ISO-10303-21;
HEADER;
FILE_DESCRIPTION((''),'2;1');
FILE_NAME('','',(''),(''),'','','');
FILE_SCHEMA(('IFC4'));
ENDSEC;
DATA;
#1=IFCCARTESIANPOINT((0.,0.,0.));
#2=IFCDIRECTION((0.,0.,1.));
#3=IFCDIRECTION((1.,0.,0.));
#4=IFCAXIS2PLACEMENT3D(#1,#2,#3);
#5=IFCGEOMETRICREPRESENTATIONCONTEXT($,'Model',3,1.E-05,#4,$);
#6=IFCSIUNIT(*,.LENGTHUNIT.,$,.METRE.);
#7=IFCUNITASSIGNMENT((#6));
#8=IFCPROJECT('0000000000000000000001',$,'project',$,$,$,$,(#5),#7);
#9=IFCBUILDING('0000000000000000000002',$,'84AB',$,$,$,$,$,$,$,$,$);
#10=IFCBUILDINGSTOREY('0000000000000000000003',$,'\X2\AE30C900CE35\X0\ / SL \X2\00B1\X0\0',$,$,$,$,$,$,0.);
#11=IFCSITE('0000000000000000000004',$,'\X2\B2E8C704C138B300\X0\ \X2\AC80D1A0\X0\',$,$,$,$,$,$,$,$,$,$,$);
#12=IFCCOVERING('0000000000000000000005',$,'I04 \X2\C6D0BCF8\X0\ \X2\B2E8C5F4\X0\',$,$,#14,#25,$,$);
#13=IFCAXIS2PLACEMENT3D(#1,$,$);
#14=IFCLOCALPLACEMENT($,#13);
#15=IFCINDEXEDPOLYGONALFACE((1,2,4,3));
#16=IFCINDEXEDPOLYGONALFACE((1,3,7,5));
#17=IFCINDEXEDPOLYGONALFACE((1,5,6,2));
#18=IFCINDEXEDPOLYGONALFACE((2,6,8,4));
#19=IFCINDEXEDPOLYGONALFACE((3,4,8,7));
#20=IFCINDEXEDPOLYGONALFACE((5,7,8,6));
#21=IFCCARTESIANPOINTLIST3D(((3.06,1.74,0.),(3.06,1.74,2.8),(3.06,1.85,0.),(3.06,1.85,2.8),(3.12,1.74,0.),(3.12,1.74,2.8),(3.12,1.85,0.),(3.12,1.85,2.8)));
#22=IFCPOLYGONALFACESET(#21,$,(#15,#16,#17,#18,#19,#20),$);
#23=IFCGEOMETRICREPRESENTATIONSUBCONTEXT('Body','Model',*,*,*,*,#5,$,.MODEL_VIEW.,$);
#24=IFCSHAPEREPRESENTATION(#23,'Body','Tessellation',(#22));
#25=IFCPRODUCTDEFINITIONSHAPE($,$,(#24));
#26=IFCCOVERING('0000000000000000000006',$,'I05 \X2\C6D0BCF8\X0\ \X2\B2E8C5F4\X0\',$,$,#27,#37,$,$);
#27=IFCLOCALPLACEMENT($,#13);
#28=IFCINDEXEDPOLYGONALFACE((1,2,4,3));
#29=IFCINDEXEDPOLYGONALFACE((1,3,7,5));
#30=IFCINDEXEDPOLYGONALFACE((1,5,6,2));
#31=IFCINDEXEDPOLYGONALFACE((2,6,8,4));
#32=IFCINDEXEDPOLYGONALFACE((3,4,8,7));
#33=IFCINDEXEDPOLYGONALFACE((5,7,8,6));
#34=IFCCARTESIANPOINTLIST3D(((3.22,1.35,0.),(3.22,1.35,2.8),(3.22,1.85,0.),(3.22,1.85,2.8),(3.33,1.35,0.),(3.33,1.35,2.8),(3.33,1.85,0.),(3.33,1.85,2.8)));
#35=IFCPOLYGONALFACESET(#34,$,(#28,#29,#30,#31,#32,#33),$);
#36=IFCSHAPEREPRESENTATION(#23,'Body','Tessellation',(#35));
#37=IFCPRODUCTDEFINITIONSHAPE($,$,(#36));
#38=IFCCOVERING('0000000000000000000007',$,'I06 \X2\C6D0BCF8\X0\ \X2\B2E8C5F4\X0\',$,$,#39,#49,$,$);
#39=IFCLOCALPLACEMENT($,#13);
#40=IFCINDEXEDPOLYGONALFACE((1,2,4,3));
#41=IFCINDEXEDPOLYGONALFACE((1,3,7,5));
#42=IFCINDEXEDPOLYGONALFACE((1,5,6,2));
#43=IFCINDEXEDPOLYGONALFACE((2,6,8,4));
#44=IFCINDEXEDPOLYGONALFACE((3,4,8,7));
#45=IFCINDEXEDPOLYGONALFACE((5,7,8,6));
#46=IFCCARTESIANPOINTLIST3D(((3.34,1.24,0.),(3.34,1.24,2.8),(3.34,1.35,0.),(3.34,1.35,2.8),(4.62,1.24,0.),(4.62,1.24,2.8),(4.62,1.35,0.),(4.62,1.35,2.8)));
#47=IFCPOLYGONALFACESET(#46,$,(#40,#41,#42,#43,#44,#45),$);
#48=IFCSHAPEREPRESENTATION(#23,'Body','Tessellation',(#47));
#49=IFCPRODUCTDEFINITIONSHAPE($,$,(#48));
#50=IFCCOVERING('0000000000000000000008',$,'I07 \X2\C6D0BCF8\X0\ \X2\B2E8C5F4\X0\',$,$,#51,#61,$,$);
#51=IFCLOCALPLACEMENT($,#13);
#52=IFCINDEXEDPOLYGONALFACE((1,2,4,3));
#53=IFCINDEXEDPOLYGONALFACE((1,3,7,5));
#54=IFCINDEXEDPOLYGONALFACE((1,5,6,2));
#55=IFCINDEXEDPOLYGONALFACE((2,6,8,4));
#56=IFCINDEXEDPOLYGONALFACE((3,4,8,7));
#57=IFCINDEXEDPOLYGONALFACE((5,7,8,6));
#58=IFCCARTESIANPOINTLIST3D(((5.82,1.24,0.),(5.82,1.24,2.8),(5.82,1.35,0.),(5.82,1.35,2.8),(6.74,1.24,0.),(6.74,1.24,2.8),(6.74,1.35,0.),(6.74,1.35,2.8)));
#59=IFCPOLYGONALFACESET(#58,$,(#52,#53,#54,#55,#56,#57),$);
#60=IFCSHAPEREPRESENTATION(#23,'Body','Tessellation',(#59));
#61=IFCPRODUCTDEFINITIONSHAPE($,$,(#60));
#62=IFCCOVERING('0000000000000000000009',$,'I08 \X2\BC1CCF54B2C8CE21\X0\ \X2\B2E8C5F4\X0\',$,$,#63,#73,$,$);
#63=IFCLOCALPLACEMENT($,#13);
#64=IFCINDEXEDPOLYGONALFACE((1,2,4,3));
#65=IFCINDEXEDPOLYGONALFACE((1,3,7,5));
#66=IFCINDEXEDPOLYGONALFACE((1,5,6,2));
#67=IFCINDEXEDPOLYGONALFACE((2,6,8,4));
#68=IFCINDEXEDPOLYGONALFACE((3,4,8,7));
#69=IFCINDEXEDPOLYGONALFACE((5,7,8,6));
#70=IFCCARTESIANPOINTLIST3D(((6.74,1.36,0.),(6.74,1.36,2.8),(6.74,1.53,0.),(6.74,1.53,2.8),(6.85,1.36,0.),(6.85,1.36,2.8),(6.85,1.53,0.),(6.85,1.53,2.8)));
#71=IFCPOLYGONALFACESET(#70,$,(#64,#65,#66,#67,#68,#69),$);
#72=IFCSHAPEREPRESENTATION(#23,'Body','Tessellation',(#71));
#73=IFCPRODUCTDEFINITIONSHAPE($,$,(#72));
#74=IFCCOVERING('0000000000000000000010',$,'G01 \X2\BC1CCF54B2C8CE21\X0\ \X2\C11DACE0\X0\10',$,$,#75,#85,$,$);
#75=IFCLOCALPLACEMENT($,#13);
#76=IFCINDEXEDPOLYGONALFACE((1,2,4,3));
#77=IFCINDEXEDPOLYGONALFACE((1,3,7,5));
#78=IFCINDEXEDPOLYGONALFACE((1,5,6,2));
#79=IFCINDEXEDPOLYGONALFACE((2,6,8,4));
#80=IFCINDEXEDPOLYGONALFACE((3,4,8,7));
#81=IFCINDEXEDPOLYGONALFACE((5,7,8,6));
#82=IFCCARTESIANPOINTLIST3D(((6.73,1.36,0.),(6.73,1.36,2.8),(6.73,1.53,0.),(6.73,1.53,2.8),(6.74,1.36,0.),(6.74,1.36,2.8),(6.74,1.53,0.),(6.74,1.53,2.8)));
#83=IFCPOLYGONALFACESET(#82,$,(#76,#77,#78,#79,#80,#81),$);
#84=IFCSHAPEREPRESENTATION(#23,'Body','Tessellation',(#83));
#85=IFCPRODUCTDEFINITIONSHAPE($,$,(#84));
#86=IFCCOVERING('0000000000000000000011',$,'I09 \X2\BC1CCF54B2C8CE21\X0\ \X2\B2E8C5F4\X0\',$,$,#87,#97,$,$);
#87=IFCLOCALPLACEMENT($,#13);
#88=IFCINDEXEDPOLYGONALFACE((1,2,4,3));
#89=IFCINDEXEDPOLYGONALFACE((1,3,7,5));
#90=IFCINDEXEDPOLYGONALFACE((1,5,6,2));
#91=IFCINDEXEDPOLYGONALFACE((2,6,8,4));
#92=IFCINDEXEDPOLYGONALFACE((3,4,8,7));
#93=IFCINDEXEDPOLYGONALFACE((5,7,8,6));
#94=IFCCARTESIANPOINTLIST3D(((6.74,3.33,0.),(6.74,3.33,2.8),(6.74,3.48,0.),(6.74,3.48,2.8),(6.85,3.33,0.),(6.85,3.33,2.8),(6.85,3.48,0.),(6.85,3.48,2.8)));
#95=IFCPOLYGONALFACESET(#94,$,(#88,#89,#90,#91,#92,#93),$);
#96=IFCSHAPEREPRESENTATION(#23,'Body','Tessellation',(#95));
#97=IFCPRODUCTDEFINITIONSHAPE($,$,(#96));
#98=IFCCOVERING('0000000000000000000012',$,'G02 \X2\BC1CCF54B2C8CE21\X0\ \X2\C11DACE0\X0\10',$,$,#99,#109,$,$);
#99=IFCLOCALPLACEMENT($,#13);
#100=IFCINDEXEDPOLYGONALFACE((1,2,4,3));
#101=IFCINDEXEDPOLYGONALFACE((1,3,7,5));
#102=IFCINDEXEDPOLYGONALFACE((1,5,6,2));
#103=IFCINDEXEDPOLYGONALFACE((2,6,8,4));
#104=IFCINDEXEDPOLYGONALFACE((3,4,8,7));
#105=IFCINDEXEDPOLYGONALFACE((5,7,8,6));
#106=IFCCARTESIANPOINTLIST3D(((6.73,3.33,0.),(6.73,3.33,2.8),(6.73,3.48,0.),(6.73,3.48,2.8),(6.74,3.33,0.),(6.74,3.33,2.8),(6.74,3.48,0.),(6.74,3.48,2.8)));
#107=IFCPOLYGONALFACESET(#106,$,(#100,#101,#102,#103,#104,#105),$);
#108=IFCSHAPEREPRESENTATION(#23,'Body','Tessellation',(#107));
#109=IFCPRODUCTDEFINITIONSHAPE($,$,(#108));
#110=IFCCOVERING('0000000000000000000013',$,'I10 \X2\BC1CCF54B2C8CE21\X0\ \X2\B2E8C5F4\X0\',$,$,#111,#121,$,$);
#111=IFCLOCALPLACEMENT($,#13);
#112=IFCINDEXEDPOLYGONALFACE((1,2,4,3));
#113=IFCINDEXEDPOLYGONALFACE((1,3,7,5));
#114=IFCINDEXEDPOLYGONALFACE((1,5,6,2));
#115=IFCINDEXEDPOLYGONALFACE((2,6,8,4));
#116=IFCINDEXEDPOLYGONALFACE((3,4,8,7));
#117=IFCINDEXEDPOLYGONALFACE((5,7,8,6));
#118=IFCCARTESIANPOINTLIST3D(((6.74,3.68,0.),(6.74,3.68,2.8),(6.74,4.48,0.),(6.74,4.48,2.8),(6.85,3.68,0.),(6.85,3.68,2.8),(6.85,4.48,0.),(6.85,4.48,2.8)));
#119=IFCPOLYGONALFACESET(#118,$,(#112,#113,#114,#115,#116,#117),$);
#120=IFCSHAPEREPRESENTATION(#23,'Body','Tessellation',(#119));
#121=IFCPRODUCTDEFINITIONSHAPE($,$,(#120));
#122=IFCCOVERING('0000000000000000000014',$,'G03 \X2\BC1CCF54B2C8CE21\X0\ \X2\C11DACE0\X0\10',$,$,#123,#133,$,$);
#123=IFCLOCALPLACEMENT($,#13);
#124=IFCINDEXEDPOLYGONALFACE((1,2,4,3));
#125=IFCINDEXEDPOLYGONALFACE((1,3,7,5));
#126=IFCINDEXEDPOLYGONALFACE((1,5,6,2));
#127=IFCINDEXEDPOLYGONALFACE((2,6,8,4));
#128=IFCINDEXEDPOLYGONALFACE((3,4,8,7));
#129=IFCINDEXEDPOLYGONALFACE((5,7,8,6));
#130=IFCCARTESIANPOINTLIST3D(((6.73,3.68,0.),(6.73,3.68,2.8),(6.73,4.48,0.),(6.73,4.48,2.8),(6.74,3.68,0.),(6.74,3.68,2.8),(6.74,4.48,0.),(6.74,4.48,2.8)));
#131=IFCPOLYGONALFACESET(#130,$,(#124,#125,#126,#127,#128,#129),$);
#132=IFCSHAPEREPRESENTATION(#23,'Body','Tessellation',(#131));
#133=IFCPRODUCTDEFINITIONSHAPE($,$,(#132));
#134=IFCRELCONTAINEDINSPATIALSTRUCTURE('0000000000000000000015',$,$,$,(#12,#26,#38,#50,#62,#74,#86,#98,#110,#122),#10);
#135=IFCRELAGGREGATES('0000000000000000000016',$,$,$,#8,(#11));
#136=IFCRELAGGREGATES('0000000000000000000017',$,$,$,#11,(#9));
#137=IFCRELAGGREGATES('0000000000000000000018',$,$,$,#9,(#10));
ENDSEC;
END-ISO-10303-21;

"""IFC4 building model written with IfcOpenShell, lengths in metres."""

from ifc_helpers import new_model, si_unit, origin, origin_with_axes, place, context, subcontext, project, spatial, polyline, outline, extrude, element, save


model = new_model("IFC4")

# Units and contexts
model_context = context("Model", 3, precision=1e-05, world=origin_with_axes())
body_context = subcontext(model_context, "Body", "Model", "MODEL_VIEW")
ifc_project = project(units=[si_unit("LENGTHUNIT", "METRE")], contexts=[model_context])

# Site, building, storey
site = spatial("IfcSite", under=ifc_project, Name="단위세대 검토")
building = spatial("IfcBuilding", under=site, Name="84AB")
storey = spatial("IfcBuildingStorey", under=building, Name="기준층 / SL ±0", Elevation=0.0)

# Coverings
covering_1_placement = place(None, origin_with_axes())
element("IfcCovering", 1, at=covering_1_placement, inside=storey, Name="I04 원본 단열", context=body_context, shape_type="SweptSolid", body=[
    extrude(outline(polyline([(3.12, 1.74), (3.12, 1.85), (3.06, 1.85), (3.06, 1.74), (3.12, 1.74)])), origin(), (0.0, 0.0, 1.0), 2.8),
])
covering_2_placement = place(None, origin_with_axes())
element("IfcCovering", 2, at=covering_2_placement, inside=storey, Name="I05 원본 단열", context=body_context, shape_type="SweptSolid", body=[
    extrude(outline(polyline([(3.33, 1.35), (3.33, 1.85), (3.22, 1.85), (3.22, 1.35), (3.33, 1.35)])), origin(), (0.0, 0.0, 1.0), 2.8),
])
covering_3_placement = place(None, origin_with_axes())
element("IfcCovering", 3, at=covering_3_placement, inside=storey, Name="I06 원본 단열", context=body_context, shape_type="SweptSolid", body=[
    extrude(outline(polyline([(4.62, 1.24), (4.62, 1.35), (3.34, 1.35), (3.34, 1.24), (4.62, 1.24)])), origin(), (0.0, 0.0, 1.0), 2.8),
])
covering_4_placement = place(None, origin_with_axes())
element("IfcCovering", 4, at=covering_4_placement, inside=storey, Name="I07 원본 단열", context=body_context, shape_type="SweptSolid", body=[
    extrude(outline(polyline([(6.74, 1.24), (6.74, 1.35), (5.82, 1.35), (5.82, 1.24), (6.74, 1.24)])), origin(), (0.0, 0.0, 1.0), 2.8),
])
covering_5_placement = place(None, origin_with_axes())
element("IfcCovering", 5, at=covering_5_placement, inside=storey, Name="I08 발코니측 단열", context=body_context, shape_type="SweptSolid", body=[
    extrude(outline(polyline([(6.85, 1.36), (6.85, 1.53), (6.74, 1.53), (6.74, 1.36), (6.85, 1.36)])), origin(), (0.0, 0.0, 1.0), 2.8),
])
covering_6_placement = place(None, origin_with_axes())
element("IfcCovering", 6, at=covering_6_placement, inside=storey, Name="G01 발코니측 석고10", context=body_context, shape_type="SweptSolid", body=[
    extrude(outline(polyline([(6.74, 1.36), (6.74, 1.53), (6.73, 1.53), (6.73, 1.36), (6.74, 1.36)])), origin(), (0.0, 0.0, 1.0), 2.8),
])
covering_7_placement = place(None, origin_with_axes())
element("IfcCovering", 7, at=covering_7_placement, inside=storey, Name="I09 발코니측 단열", context=body_context, shape_type="SweptSolid", body=[
    extrude(outline(polyline([(6.85, 3.33), (6.85, 3.48), (6.74, 3.48), (6.74, 3.33), (6.85, 3.33)])), origin(), (0.0, 0.0, 1.0), 2.8),
])
covering_8_placement = place(None, origin_with_axes())
element("IfcCovering", 8, at=covering_8_placement, inside=storey, Name="G02 발코니측 석고10", context=body_context, shape_type="SweptSolid", body=[
    extrude(outline(polyline([(6.74, 3.33), (6.74, 3.48), (6.73, 3.48), (6.73, 3.33), (6.74, 3.33)])), origin(), (0.0, 0.0, 1.0), 2.8),
])
covering_9_placement = place(None, origin_with_axes())
element("IfcCovering", 9, at=covering_9_placement, inside=storey, Name="I10 발코니측 단열", context=body_context, shape_type="SweptSolid", body=[
    extrude(outline(polyline([(6.85, 3.68), (6.85, 4.48), (6.74, 4.48), (6.74, 3.68), (6.85, 3.68)])), origin(), (0.0, 0.0, 1.0), 2.8),
])
covering_10_placement = place(None, origin_with_axes())
element("IfcCovering", 10, at=covering_10_placement, inside=storey, Name="G03 발코니측 석고10", context=body_context, shape_type="SweptSolid", body=[
    extrude(outline(polyline([(6.74, 3.68), (6.74, 4.48), (6.73, 4.48), (6.73, 3.68), (6.74, 3.68)])), origin(), (0.0, 0.0, 1.0), 2.8),
])

save(model, "model.ifc")
